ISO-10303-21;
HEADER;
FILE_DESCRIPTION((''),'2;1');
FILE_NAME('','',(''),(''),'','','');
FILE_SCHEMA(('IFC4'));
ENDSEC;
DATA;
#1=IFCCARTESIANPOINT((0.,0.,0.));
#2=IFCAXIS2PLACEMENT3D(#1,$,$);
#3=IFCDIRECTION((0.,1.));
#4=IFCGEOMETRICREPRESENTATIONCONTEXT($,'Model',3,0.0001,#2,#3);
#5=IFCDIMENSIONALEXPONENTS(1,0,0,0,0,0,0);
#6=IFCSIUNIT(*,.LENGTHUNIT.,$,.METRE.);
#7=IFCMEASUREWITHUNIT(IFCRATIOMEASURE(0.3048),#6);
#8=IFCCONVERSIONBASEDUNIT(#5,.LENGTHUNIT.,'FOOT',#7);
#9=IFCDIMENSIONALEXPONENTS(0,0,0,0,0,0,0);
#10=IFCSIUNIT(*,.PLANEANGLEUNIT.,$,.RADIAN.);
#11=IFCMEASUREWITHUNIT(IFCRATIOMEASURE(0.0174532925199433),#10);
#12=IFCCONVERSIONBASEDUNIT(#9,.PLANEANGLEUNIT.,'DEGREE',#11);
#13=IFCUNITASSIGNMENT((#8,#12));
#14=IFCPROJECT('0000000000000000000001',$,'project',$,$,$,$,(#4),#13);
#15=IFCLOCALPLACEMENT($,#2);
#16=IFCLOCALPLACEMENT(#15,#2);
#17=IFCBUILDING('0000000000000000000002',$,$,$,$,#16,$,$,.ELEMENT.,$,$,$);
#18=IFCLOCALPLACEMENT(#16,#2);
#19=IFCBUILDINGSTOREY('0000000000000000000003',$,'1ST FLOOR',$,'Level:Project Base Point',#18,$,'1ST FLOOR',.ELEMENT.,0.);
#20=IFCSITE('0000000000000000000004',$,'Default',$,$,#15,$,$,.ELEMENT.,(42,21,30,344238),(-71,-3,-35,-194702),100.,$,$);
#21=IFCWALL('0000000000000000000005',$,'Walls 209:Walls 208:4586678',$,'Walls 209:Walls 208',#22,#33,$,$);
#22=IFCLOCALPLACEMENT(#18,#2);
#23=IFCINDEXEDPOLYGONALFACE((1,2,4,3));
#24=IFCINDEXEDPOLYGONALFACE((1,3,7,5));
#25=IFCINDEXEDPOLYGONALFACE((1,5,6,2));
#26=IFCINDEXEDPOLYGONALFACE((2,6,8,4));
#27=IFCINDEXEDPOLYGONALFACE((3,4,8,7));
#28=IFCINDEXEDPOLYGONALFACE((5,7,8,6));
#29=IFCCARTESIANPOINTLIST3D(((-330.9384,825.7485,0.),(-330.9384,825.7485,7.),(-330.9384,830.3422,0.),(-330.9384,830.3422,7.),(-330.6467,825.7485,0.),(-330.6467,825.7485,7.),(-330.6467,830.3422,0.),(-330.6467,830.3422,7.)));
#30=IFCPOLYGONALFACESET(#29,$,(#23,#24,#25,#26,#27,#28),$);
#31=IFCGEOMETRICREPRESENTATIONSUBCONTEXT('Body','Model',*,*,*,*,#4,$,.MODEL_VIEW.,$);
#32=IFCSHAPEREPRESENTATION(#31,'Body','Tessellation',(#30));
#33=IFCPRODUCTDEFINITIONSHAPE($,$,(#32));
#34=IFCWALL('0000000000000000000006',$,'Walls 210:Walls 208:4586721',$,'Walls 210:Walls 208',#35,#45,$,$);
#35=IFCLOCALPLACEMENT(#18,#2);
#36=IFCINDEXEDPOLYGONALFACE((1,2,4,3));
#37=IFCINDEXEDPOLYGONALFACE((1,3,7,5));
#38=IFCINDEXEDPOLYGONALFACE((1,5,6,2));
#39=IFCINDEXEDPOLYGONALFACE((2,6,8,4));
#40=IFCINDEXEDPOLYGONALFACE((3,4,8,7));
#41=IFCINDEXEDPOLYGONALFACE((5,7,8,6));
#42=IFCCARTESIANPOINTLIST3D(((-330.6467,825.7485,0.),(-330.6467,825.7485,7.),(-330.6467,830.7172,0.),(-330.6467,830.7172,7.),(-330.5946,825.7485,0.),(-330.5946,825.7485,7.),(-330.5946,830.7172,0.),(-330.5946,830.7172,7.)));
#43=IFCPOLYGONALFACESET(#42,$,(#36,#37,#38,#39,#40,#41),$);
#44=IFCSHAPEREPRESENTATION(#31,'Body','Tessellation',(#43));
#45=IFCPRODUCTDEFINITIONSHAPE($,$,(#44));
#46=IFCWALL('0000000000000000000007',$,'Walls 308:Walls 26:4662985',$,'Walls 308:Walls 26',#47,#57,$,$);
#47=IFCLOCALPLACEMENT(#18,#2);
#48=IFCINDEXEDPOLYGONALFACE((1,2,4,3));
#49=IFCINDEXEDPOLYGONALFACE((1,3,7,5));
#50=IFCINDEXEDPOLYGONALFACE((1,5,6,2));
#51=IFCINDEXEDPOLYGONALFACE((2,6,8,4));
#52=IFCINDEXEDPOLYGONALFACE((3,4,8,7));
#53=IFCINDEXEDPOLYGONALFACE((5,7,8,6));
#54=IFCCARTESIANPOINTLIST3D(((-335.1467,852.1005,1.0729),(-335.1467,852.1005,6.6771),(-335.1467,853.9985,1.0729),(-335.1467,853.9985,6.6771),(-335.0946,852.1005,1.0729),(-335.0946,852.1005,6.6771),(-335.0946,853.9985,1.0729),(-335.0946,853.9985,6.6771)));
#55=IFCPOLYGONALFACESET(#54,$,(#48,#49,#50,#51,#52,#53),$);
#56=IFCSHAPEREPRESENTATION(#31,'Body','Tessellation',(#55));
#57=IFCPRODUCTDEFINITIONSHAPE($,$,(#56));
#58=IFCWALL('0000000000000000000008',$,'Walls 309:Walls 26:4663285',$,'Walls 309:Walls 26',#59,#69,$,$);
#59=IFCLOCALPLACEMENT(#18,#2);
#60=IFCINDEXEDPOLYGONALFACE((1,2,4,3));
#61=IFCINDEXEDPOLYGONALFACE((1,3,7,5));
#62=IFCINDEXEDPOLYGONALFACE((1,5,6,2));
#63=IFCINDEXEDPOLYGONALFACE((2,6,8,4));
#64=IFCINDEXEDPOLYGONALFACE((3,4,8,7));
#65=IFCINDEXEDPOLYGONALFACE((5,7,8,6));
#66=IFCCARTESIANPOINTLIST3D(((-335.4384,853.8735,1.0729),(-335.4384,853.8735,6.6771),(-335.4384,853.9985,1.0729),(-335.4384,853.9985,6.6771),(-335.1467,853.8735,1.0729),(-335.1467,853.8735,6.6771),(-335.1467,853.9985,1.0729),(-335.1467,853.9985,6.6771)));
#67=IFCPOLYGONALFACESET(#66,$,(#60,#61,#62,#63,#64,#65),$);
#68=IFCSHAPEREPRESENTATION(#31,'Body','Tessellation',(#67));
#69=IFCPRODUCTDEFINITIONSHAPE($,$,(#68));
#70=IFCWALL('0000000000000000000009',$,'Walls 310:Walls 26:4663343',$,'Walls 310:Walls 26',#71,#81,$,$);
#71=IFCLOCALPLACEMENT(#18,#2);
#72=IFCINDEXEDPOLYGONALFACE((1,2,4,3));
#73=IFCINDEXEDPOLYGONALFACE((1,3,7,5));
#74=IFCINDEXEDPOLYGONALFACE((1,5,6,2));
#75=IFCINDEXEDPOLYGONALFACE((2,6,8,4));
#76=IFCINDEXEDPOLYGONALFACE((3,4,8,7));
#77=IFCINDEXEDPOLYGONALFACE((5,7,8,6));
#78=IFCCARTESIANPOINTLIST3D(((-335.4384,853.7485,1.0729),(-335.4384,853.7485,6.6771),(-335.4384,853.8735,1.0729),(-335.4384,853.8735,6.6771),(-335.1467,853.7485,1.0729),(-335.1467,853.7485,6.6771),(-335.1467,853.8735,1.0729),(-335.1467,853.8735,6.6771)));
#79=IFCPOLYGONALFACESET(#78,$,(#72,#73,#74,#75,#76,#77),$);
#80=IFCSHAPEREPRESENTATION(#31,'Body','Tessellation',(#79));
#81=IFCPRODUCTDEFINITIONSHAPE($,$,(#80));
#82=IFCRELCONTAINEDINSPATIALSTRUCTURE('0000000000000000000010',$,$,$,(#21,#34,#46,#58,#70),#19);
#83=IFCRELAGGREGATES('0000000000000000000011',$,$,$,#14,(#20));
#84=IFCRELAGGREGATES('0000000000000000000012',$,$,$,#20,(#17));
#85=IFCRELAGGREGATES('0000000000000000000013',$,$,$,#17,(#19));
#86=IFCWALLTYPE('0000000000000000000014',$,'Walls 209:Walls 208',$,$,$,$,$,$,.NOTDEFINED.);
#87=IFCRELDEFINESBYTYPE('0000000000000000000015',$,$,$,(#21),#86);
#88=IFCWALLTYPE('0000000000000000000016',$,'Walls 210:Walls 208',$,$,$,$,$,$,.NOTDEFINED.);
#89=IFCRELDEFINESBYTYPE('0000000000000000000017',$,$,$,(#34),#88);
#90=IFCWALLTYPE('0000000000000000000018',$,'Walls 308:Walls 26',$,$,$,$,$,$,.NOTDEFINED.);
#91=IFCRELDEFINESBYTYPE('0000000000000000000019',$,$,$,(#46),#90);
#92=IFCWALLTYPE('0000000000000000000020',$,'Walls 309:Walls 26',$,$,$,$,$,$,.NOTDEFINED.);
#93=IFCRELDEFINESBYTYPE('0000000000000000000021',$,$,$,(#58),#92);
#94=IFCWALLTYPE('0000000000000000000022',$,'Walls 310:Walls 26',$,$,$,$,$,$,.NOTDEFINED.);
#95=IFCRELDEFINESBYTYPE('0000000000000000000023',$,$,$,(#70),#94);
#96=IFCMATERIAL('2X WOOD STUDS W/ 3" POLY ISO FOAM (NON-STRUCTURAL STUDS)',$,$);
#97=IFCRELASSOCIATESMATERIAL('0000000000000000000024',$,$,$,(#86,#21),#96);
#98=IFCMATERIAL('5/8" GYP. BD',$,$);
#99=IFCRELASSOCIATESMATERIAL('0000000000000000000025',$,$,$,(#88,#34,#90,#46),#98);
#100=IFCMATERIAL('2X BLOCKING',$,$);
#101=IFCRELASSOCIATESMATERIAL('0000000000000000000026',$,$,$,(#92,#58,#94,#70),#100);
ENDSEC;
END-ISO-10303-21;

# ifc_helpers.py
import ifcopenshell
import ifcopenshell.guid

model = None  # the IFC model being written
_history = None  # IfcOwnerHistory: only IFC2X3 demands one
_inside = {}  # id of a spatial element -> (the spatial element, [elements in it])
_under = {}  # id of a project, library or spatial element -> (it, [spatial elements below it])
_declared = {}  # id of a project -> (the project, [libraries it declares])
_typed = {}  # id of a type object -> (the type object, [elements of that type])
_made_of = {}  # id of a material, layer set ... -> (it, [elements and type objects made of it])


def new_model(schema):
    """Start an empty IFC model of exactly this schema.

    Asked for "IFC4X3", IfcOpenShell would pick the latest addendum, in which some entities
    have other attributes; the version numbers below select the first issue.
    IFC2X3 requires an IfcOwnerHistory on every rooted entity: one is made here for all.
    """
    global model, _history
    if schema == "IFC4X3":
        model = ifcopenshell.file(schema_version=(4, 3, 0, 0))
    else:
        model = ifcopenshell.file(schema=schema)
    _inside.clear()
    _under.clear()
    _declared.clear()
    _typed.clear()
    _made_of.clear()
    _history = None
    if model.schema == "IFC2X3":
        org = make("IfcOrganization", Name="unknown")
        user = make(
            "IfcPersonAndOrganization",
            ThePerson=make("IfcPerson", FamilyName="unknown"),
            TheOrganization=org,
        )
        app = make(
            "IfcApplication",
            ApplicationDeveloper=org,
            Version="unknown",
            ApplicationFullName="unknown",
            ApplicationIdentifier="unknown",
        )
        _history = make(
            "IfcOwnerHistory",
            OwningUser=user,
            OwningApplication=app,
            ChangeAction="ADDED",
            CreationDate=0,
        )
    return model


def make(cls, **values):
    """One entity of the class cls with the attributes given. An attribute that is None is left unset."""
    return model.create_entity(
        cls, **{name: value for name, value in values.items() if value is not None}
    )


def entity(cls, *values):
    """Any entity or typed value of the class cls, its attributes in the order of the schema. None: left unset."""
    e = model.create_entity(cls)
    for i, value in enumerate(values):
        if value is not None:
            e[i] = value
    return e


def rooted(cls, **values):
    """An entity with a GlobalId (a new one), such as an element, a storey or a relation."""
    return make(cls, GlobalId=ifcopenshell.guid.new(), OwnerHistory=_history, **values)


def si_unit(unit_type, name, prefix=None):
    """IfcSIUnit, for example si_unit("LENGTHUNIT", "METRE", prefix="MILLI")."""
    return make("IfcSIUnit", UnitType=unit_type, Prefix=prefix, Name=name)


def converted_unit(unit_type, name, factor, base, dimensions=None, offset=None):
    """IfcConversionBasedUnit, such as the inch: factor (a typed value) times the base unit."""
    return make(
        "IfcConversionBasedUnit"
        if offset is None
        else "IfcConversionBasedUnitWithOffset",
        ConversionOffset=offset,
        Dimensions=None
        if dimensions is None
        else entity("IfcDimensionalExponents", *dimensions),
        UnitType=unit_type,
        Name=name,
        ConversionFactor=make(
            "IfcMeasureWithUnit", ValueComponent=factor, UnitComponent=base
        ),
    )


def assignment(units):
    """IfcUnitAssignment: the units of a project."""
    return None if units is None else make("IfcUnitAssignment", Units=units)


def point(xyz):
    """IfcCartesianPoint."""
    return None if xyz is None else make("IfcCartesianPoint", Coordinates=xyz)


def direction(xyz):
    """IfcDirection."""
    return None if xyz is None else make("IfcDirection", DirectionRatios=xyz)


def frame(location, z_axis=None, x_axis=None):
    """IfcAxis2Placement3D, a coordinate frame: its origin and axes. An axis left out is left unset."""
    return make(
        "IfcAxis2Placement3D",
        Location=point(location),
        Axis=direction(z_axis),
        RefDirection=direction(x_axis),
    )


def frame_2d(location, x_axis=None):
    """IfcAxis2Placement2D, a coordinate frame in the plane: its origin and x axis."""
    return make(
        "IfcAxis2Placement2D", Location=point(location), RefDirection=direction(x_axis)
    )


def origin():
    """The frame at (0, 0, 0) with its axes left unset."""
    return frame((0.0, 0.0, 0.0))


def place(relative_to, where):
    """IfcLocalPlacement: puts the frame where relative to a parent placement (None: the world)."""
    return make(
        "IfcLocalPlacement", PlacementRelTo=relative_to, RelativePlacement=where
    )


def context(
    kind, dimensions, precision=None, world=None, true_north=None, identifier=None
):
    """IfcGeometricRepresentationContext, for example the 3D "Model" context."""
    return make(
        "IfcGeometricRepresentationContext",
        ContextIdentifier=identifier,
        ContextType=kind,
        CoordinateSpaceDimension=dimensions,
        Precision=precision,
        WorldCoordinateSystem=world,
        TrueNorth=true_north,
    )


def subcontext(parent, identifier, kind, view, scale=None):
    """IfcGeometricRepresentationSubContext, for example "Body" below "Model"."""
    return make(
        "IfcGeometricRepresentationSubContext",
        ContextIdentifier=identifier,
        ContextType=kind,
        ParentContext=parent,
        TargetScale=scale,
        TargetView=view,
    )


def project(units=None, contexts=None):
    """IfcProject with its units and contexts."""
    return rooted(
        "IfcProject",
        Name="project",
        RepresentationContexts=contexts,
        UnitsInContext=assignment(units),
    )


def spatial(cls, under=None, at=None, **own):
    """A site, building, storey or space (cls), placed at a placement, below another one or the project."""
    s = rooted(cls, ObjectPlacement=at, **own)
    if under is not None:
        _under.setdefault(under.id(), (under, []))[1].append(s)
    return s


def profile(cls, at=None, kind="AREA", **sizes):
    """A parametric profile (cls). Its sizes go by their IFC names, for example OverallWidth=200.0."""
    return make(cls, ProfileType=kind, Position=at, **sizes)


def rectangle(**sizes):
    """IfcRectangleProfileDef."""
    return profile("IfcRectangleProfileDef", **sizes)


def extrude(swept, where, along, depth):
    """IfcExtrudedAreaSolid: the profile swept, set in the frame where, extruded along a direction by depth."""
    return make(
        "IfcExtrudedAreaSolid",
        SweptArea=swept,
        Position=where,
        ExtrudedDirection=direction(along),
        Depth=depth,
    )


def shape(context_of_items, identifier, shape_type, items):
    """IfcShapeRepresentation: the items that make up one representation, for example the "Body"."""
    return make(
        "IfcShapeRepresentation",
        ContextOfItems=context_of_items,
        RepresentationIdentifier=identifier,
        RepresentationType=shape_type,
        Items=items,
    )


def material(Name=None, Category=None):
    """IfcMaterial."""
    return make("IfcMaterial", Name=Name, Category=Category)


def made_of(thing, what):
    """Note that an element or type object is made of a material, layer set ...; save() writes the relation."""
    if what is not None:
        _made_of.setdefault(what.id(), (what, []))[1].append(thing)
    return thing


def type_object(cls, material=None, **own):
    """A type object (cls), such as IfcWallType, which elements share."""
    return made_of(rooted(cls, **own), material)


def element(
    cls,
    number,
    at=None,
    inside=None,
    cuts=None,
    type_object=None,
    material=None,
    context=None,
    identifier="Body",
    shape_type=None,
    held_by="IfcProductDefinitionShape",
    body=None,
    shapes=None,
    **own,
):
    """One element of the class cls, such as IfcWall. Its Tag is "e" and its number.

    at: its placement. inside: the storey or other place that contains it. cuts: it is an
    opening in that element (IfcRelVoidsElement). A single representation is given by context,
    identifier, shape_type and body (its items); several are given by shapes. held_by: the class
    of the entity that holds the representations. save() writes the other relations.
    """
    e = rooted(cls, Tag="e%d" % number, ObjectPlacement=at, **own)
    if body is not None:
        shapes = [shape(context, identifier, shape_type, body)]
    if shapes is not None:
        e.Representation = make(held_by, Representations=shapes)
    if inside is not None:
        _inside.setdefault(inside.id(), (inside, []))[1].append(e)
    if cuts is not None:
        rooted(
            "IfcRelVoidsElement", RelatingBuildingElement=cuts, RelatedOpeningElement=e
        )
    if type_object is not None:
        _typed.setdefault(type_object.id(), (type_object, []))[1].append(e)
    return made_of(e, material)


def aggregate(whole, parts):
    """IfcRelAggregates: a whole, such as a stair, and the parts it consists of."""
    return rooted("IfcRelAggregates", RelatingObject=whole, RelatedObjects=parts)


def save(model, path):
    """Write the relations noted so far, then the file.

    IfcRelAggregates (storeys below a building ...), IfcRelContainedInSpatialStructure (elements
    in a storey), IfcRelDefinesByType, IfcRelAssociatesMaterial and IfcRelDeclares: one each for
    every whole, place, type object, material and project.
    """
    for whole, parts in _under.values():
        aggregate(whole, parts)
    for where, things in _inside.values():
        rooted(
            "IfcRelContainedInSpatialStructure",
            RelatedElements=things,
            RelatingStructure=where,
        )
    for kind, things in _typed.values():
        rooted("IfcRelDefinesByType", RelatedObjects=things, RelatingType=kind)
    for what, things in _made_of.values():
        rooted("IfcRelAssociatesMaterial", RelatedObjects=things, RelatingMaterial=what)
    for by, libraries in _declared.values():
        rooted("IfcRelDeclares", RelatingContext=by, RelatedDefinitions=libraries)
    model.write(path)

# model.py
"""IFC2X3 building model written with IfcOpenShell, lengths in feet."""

from ifc_helpers import new_model, entity, si_unit, converted_unit, direction, frame, frame_2d, origin, place, context, subcontext, project, spatial, rectangle, extrude, material, type_object, element, save


model = new_model("IFC2X3")

# Units and contexts
model_context = context("Model", 3, precision=0.0001, world=origin(), true_north=direction((0.0, 1.0)))
body_context = subcontext(model_context, "Body", "Model", "MODEL_VIEW")
ifc_project = project(units=[converted_unit("LENGTHUNIT", "FOOT", entity("IfcRatioMeasure", 0.3048), si_unit("LENGTHUNIT", "METRE"), dimensions=[1, 0, 0, 0, 0, 0, 0]), converted_unit("PLANEANGLEUNIT", "DEGREE", entity("IfcRatioMeasure", 0.0174532925199433), si_unit("PLANEANGLEUNIT", "RADIAN"), dimensions=[0, 0, 0, 0, 0, 0, 0])], contexts=[model_context])

# Site, building, storey
site_placement = place(None, origin())
site = spatial("IfcSite", under=ifc_project, at=site_placement, Name="Default", CompositionType="ELEMENT", RefLatitude=(42, 21, 30, 344238), RefLongitude=(-71, -3, -35, -194702), RefElevation=100.0)
building_placement = place(site_placement, origin())
building = spatial("IfcBuilding", under=site, at=building_placement, CompositionType="ELEMENT")
storey_placement = place(building_placement, origin())
storey = spatial("IfcBuildingStorey", under=building, at=storey_placement, Name="1ST FLOOR", ObjectType="Level:Project Base Point", LongName="1ST FLOOR", CompositionType="ELEMENT", Elevation=0.0)

# Walls
ifc_material_1 = material(Name="2X BLOCKING")
ifc_material_2 = material(Name="2X WOOD STUDS W/ 3\" POLY ISO FOAM (NON-STRUCTURAL STUDS)")
wall_type_1 = type_object("IfcWallType", Name="Walls 209:Walls 208", PredefinedType="NOTDEFINED", material=ifc_material_2)
wall_1_placement = place(storey_placement, frame((-330.9384, 825.7485, 0.0), z_axis=(0.0, 0.0, 1.0), x_axis=(0.0, 1.0, 0.0)))
element("IfcWall", 1, at=wall_1_placement, inside=storey, type_object=wall_type_1, material=ifc_material_2, Name="Walls 209:Walls 208:4586678", ObjectType="Walls 209:Walls 208", context=body_context, shape_type="SweptSolid", body=[
    extrude(rectangle(XDim=4.5938, YDim=0.2917, at=frame_2d((0.0, 0.0), x_axis=(1.0, 0.0))), frame((2.2969, -0.1458, 0.0), z_axis=(0.0, 0.0, 1.0), x_axis=(-1.0, 0.0, 0.0)), (0.0, 0.0, 1.0), 7.0),
])
ifc_material_3 = material(Name="5/8\" GYP. BD")
wall_type_2 = type_object("IfcWallType", Name="Walls 210:Walls 208", PredefinedType="NOTDEFINED", material=ifc_material_3)
wall_2_placement = place(storey_placement, frame((-330.6467, 825.7485, 0.0), z_axis=(0.0, 0.0, 1.0), x_axis=(0.0, 1.0, 0.0)))
element("IfcWall", 2, at=wall_2_placement, inside=storey, type_object=wall_type_2, material=ifc_material_3, Name="Walls 210:Walls 208:4586721", ObjectType="Walls 210:Walls 208", context=body_context, shape_type="SweptSolid", body=[
    extrude(rectangle(XDim=4.9687, YDim=0.0521, at=frame_2d((0.0, 0.0), x_axis=(1.0, 0.0))), frame((2.4844, -0.026, 0.0), z_axis=(0.0, 0.0, 1.0), x_axis=(-1.0, 0.0, 0.0)), (0.0, 0.0, 1.0), 7.0),
])
wall_type_3 = type_object("IfcWallType", Name="Walls 308:Walls 26", PredefinedType="NOTDEFINED", material=ifc_material_3)
wall_3_placement = place(storey_placement, frame((-335.1467, 852.1005, 1.0729), z_axis=(0.0, 0.0, 1.0), x_axis=(0.0, 1.0, 0.0)))
element("IfcWall", 3, at=wall_3_placement, inside=storey, type_object=wall_type_3, material=ifc_material_3, Name="Walls 308:Walls 26:4662985", ObjectType="Walls 308:Walls 26", context=body_context, shape_type="SweptSolid", body=[
    extrude(rectangle(XDim=0.0521, YDim=1.898, at=frame_2d((0.0, 0.0), x_axis=(1.0, 0.0))), frame((0.949, -0.026, 0.0), z_axis=(0.0, 0.0, 1.0), x_axis=(0.0, 1.0, 0.0)), (0.0, 0.0, 1.0), 5.6042),
])
wall_type_4 = type_object("IfcWallType", Name="Walls 309:Walls 26", PredefinedType="NOTDEFINED", material=ifc_material_1)
wall_4_placement = place(storey_placement, frame((-335.4384, 853.7485, 1.0729)))
element("IfcWall", 4, at=wall_4_placement, inside=storey, type_object=wall_type_4, material=ifc_material_1, Name="Walls 309:Walls 26:4663285", ObjectType="Walls 309:Walls 26", context=body_context, shape_type="SweptSolid", body=[
    extrude(rectangle(XDim=0.2917, YDim=0.125, at=frame_2d((0.0, 0.0), x_axis=(1.0, 0.0))), frame((0.1458, 0.1875, 0.0), z_axis=(0.0, 0.0, 1.0), x_axis=(-1.0, 0.0, 0.0)), (0.0, 0.0, 1.0), 5.6042),
])
wall_type_5 = type_object("IfcWallType", Name="Walls 310:Walls 26", PredefinedType="NOTDEFINED", material=ifc_material_1)
wall_5_placement = place(storey_placement, frame((-335.4384, 853.6235, 1.0729)))
element("IfcWall", 5, at=wall_5_placement, inside=storey, type_object=wall_type_5, material=ifc_material_1, Name="Walls 310:Walls 26:4663343", ObjectType="Walls 310:Walls 26", context=body_context, shape_type="SweptSolid", body=[
    extrude(rectangle(XDim=0.2917, YDim=0.125, at=frame_2d((0.0, 0.0), x_axis=(1.0, 0.0))), frame((0.1458, 0.1875, 0.0), z_axis=(0.0, 0.0, 1.0), x_axis=(-1.0, 0.0, 0.0)), (0.0, 0.0, 1.0), 5.6042),
])

save(model, "model.ifc")
